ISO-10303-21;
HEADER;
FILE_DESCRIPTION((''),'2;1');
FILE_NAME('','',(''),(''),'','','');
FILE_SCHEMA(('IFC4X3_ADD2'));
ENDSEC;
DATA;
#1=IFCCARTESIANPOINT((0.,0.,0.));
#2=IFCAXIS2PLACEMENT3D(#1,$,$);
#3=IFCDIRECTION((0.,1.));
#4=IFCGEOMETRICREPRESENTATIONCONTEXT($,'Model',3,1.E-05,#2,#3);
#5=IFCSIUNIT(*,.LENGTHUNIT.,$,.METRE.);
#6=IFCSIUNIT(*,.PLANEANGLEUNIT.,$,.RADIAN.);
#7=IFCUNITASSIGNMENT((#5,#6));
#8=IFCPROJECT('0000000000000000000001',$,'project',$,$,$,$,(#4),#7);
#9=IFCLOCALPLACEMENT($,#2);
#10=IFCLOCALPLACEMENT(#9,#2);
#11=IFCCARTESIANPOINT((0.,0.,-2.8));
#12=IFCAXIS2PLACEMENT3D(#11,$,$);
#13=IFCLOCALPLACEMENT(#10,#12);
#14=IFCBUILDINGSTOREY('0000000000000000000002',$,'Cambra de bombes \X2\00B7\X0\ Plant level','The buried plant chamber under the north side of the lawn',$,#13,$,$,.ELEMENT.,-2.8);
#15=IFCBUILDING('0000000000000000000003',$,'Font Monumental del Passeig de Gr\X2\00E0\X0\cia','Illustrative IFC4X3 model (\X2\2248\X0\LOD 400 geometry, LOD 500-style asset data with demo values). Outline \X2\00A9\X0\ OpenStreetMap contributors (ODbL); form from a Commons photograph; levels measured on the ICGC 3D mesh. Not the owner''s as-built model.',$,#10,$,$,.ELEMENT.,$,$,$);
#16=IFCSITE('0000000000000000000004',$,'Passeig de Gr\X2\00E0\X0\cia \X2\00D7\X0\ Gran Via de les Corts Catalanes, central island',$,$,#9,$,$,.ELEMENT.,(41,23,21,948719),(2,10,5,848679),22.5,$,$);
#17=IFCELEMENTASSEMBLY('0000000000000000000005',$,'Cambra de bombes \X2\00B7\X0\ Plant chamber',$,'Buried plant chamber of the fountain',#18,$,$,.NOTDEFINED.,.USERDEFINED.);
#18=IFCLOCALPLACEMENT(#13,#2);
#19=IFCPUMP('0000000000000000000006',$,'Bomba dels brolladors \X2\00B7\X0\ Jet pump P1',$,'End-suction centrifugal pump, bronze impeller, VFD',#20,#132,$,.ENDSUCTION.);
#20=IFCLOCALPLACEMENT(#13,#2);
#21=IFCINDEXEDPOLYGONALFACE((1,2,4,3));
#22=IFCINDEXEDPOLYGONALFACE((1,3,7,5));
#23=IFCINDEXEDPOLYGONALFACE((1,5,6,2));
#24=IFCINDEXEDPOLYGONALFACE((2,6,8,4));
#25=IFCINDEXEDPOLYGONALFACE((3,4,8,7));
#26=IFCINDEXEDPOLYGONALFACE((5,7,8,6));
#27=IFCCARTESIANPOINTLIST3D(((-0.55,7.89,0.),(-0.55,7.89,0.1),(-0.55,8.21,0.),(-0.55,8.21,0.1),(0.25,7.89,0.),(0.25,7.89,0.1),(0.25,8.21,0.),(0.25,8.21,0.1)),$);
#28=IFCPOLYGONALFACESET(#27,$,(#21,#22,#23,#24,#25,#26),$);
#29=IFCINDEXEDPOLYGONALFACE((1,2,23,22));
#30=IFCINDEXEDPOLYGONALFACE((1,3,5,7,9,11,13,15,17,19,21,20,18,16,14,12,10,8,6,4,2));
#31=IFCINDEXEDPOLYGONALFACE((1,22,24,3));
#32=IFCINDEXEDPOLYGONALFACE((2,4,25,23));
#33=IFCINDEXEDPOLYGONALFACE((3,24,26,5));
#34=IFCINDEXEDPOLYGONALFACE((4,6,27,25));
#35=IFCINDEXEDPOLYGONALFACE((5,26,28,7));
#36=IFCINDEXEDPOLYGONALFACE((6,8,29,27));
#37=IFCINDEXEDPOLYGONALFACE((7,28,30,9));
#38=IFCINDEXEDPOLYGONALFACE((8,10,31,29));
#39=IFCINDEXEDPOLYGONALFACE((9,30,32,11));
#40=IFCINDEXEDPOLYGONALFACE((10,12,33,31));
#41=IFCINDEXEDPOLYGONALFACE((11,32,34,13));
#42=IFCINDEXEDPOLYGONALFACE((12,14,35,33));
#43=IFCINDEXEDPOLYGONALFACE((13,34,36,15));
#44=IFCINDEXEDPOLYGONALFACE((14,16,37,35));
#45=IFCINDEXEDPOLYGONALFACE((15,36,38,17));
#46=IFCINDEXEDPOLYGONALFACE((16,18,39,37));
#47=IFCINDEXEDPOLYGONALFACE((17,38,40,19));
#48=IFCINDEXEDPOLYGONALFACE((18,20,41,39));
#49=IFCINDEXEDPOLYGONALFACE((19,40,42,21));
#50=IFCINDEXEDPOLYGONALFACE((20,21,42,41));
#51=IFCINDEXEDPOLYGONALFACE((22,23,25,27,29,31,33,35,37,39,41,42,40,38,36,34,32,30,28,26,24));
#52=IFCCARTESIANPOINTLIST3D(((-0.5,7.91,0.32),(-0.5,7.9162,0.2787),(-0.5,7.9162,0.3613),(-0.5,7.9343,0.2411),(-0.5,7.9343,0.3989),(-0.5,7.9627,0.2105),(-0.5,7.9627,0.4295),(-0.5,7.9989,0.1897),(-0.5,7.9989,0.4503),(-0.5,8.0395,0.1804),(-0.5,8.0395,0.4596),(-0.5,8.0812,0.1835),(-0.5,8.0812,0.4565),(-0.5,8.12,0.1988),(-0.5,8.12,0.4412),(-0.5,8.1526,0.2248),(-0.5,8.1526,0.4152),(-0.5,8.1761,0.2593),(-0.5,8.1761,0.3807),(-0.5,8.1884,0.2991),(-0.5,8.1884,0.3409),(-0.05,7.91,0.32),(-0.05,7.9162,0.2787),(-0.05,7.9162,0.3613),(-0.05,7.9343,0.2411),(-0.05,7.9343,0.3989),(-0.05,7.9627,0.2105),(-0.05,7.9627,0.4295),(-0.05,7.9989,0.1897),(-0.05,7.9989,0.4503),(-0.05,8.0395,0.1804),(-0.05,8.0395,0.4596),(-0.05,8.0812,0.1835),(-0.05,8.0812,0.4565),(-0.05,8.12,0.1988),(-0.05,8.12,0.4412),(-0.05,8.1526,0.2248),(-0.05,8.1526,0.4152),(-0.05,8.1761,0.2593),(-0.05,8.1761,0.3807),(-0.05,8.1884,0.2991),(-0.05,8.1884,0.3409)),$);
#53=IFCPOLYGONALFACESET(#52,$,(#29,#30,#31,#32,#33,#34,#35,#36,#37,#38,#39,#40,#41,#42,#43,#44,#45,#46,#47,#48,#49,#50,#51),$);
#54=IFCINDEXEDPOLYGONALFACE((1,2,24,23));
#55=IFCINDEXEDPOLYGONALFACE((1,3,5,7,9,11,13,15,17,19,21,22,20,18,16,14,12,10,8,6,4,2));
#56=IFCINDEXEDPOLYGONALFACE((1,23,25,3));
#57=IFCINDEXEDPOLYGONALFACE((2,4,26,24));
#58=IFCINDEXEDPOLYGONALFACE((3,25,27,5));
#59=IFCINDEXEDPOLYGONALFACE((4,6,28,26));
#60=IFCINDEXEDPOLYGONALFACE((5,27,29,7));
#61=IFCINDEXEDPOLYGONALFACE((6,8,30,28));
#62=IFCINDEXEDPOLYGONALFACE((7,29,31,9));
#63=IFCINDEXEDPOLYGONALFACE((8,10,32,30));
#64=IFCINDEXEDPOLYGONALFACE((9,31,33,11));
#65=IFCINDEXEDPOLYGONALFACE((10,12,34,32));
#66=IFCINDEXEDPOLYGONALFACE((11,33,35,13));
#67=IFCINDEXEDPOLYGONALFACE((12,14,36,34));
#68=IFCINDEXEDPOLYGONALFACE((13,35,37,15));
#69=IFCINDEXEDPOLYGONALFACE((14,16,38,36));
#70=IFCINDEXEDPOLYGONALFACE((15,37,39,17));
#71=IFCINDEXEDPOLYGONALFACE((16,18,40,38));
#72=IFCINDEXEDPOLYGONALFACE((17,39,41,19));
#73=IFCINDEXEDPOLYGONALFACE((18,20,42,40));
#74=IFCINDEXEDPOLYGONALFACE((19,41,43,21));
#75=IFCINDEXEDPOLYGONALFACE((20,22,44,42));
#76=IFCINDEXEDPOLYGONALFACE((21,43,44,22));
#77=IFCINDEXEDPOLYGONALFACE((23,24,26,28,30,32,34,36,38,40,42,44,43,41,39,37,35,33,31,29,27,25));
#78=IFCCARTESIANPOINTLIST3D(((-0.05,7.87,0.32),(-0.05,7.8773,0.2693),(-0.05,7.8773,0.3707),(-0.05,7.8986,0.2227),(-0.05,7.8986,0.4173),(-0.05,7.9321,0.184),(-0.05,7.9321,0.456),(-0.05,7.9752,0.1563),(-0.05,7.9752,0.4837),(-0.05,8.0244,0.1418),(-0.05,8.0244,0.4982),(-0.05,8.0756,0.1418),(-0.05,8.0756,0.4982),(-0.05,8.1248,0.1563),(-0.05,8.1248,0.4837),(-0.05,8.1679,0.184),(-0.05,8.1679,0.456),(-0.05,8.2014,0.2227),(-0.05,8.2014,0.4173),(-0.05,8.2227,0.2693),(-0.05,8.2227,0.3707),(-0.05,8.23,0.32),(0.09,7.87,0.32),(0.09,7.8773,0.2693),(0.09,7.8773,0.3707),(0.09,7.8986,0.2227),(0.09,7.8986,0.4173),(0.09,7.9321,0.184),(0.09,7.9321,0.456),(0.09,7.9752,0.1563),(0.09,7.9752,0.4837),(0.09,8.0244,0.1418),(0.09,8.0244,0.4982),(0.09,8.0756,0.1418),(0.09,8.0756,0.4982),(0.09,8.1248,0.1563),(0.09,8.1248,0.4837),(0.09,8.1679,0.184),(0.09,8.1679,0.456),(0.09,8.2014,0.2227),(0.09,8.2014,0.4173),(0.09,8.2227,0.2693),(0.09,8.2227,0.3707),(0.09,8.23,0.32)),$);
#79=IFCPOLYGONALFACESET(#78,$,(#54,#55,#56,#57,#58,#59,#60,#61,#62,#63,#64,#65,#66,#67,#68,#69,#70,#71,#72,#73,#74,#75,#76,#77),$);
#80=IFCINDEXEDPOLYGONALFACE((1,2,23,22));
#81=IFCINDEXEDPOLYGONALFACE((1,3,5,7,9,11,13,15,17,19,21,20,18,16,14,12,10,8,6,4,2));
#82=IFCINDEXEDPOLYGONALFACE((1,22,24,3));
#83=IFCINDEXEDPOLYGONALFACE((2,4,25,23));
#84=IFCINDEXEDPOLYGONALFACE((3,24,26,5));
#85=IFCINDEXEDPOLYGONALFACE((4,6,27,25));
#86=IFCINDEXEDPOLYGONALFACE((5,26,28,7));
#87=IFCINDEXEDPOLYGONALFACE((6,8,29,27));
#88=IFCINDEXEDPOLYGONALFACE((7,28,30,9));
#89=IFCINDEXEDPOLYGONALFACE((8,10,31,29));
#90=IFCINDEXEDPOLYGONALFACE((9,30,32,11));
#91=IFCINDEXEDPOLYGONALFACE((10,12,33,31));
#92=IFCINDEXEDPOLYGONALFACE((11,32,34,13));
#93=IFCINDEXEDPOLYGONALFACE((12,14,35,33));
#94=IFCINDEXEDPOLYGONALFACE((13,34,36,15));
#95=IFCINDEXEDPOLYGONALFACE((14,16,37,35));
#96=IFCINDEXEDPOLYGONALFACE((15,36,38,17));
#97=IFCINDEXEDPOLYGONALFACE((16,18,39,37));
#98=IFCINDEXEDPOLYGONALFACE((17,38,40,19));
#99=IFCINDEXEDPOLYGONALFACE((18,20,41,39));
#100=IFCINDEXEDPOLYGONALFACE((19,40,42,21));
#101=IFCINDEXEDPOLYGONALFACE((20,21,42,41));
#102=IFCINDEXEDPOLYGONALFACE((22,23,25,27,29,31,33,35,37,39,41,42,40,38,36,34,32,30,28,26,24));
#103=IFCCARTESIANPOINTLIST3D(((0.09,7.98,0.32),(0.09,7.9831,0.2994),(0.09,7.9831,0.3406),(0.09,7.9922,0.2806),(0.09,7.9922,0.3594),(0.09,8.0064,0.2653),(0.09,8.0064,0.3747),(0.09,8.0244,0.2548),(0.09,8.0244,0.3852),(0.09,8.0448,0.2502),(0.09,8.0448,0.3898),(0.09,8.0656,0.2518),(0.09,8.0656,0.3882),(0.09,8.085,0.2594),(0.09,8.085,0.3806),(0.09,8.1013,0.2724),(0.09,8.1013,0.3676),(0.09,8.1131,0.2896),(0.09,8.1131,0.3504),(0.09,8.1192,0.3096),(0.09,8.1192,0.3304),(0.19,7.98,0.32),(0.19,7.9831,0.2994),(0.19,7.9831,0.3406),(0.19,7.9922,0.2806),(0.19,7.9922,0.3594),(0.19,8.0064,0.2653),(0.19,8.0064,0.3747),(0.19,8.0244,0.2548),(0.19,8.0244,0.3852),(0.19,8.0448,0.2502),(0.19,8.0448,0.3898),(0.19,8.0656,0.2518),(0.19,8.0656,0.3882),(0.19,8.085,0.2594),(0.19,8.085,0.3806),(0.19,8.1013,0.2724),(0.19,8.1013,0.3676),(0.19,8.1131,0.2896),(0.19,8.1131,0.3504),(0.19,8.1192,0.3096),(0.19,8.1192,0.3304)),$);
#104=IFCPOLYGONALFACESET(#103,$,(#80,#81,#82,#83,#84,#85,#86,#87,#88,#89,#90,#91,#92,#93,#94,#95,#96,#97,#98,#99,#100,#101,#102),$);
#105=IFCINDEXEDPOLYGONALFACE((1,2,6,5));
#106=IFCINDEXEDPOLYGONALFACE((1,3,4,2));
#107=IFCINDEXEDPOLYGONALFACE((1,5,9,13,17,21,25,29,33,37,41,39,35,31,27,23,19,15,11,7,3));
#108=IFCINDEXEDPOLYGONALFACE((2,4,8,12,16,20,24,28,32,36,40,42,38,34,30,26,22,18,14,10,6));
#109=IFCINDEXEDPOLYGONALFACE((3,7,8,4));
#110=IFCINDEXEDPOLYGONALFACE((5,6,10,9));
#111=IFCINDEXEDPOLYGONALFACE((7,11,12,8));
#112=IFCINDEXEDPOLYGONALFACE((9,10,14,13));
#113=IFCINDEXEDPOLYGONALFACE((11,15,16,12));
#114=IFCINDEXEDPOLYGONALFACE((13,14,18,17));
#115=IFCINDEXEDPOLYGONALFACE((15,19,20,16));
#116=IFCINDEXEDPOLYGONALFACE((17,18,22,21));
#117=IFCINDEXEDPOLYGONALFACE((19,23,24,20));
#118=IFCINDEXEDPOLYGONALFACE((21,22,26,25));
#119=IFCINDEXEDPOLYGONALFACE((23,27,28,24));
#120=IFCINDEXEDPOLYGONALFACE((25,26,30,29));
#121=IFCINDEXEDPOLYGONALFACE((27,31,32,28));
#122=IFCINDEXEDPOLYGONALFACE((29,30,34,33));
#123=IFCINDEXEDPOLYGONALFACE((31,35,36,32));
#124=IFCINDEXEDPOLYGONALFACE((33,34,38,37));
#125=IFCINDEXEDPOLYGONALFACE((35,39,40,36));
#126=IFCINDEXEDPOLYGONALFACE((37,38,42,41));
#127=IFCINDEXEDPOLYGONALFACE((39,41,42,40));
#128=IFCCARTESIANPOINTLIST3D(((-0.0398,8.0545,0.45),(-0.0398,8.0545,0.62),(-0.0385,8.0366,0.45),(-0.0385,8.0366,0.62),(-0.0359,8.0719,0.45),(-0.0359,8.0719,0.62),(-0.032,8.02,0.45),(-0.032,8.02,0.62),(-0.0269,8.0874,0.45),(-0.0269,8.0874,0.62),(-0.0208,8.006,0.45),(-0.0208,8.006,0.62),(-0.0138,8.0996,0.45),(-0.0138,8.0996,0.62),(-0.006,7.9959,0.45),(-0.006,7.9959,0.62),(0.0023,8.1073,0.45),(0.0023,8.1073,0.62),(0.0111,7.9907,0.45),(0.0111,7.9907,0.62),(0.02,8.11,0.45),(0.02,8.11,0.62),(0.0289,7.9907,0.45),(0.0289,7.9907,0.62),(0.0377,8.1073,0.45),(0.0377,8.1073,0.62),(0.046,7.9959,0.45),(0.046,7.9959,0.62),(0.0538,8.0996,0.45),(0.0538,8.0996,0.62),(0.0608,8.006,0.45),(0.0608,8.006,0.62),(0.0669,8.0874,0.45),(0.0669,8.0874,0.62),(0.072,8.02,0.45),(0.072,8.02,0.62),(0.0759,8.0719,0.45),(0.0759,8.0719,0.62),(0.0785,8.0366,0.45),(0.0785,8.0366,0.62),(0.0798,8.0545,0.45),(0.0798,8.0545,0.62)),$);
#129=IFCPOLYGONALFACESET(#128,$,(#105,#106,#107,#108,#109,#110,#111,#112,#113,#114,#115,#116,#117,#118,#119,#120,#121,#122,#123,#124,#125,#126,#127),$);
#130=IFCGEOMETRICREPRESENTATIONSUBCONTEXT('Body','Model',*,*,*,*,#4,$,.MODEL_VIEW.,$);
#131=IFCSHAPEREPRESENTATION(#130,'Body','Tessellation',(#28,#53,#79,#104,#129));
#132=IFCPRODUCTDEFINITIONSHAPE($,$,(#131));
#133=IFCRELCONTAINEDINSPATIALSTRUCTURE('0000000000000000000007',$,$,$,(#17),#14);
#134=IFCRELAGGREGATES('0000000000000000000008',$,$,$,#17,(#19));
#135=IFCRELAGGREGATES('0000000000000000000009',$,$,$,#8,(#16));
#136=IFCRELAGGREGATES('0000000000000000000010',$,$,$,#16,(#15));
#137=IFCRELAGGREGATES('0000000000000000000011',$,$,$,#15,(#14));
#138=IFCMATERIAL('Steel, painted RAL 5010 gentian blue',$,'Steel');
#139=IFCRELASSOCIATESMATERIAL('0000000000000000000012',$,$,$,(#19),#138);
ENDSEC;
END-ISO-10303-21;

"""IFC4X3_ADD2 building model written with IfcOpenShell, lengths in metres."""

from ifc_helpers import new_model, si_unit, direction, frame, origin, origin_2d_with_axis, place, context, subcontext, project, spatial, rectangle, circle, extrude, material, element, aggregate, save


model = new_model("IFC4X3_ADD2")

# Units and contexts
model_context = context("Model", 3, precision=1e-05, world=origin(), true_north=direction((0.0, 1.0)))
body_context = subcontext(model_context, "Body", "Model", "MODEL_VIEW")
ifc_project = project(units=[si_unit("LENGTHUNIT", "METRE"), si_unit("PLANEANGLEUNIT", "RADIAN")], contexts=[model_context])

# Site, building, storey
site_placement = place(None, origin())
site = spatial("IfcSite", under=ifc_project, at=site_placement, Name="Passeig de Gràcia × Gran Via de les Corts Catalanes, central island", CompositionType="ELEMENT", RefLatitude=(41, 23, 21, 948719), RefLongitude=(2, 10, 5, 848679), RefElevation=22.5)
building_placement = place(site_placement, origin())
building = spatial("IfcBuilding", under=site, at=building_placement, Name="Font Monumental del Passeig de Gràcia", Description="Illustrative IFC4X3 model (≈LOD 400 geometry, LOD 500-style asset data with demo values). Outline © OpenStreetMap contributors (ODbL); form from a Commons photograph; levels measured on the ICGC 3D mesh. Not the owner's as-built model.", CompositionType="ELEMENT")
storey_placement = place(building_placement, frame((0.0, 0.0, -2.8)))
storey = spatial("IfcBuildingStorey", under=building, at=storey_placement, Name="Cambra de bombes · Plant level", Description="The buried plant chamber under the north side of the lawn", CompositionType="ELEMENT", Elevation=-2.8)

# Element assembly, pump
assembly_1_placement = place(building_placement, origin())
assembly_1 = element("IfcElementAssembly", 1, at=assembly_1_placement, inside=storey, Name="Cambra de bombes · Plant chamber", ObjectType="Buried plant chamber of the fountain", AssemblyPlace="NOTDEFINED", PredefinedType="USERDEFINED")
ifc_material_1 = material(Name="Steel, painted RAL 5010 gentian blue", Category="Steel")
pump_1_placement = place(building_placement, origin())
pump_1 = element("IfcPump", 2, at=pump_1_placement, material=ifc_material_1, Name="Bomba dels brolladors · Jet pump P1", ObjectType="End-suction centrifugal pump, bronze impeller, VFD", PredefinedType="ENDSUCTION", context=body_context, shape_type="SweptSolid", body=[
    extrude(rectangle(XDim=0.8, YDim=0.32, at=origin_2d_with_axis()), frame((-0.15, 8.05, -2.8)), (0.0, 0.0, 1.0), 0.1),
    extrude(circle(Radius=0.14, at=origin_2d_with_axis()), frame((-0.5, 8.05, -2.48), z_axis=(1.0, 0.0, 0.0), x_axis=(0.0, -1.0, 0.0)), (0.0, 0.0, 1.0), 0.45),
    extrude(circle(Radius=0.18, at=origin_2d_with_axis()), frame((-0.05, 8.05, -2.48), z_axis=(1.0, 0.0, 0.0), x_axis=(0.0, -1.0, 0.0)), (0.0, 0.0, 1.0), 0.14),
    extrude(circle(Radius=0.07, at=origin_2d_with_axis()), frame((0.09, 8.05, -2.48), z_axis=(1.0, 0.0, 0.0), x_axis=(0.0, -1.0, 0.0)), (0.0, 0.0, 1.0), 0.1),
    extrude(circle(Radius=0.06, at=origin_2d_with_axis()), frame((0.02, 8.05, -2.35), z_axis=(0.0, 0.0, 1.0), x_axis=(0.0, 1.0, 0.0)), (0.0, 0.0, 1.0), 0.17),
])
aggregate(assembly_1, [pump_1])

save(model, "model.ifc")
